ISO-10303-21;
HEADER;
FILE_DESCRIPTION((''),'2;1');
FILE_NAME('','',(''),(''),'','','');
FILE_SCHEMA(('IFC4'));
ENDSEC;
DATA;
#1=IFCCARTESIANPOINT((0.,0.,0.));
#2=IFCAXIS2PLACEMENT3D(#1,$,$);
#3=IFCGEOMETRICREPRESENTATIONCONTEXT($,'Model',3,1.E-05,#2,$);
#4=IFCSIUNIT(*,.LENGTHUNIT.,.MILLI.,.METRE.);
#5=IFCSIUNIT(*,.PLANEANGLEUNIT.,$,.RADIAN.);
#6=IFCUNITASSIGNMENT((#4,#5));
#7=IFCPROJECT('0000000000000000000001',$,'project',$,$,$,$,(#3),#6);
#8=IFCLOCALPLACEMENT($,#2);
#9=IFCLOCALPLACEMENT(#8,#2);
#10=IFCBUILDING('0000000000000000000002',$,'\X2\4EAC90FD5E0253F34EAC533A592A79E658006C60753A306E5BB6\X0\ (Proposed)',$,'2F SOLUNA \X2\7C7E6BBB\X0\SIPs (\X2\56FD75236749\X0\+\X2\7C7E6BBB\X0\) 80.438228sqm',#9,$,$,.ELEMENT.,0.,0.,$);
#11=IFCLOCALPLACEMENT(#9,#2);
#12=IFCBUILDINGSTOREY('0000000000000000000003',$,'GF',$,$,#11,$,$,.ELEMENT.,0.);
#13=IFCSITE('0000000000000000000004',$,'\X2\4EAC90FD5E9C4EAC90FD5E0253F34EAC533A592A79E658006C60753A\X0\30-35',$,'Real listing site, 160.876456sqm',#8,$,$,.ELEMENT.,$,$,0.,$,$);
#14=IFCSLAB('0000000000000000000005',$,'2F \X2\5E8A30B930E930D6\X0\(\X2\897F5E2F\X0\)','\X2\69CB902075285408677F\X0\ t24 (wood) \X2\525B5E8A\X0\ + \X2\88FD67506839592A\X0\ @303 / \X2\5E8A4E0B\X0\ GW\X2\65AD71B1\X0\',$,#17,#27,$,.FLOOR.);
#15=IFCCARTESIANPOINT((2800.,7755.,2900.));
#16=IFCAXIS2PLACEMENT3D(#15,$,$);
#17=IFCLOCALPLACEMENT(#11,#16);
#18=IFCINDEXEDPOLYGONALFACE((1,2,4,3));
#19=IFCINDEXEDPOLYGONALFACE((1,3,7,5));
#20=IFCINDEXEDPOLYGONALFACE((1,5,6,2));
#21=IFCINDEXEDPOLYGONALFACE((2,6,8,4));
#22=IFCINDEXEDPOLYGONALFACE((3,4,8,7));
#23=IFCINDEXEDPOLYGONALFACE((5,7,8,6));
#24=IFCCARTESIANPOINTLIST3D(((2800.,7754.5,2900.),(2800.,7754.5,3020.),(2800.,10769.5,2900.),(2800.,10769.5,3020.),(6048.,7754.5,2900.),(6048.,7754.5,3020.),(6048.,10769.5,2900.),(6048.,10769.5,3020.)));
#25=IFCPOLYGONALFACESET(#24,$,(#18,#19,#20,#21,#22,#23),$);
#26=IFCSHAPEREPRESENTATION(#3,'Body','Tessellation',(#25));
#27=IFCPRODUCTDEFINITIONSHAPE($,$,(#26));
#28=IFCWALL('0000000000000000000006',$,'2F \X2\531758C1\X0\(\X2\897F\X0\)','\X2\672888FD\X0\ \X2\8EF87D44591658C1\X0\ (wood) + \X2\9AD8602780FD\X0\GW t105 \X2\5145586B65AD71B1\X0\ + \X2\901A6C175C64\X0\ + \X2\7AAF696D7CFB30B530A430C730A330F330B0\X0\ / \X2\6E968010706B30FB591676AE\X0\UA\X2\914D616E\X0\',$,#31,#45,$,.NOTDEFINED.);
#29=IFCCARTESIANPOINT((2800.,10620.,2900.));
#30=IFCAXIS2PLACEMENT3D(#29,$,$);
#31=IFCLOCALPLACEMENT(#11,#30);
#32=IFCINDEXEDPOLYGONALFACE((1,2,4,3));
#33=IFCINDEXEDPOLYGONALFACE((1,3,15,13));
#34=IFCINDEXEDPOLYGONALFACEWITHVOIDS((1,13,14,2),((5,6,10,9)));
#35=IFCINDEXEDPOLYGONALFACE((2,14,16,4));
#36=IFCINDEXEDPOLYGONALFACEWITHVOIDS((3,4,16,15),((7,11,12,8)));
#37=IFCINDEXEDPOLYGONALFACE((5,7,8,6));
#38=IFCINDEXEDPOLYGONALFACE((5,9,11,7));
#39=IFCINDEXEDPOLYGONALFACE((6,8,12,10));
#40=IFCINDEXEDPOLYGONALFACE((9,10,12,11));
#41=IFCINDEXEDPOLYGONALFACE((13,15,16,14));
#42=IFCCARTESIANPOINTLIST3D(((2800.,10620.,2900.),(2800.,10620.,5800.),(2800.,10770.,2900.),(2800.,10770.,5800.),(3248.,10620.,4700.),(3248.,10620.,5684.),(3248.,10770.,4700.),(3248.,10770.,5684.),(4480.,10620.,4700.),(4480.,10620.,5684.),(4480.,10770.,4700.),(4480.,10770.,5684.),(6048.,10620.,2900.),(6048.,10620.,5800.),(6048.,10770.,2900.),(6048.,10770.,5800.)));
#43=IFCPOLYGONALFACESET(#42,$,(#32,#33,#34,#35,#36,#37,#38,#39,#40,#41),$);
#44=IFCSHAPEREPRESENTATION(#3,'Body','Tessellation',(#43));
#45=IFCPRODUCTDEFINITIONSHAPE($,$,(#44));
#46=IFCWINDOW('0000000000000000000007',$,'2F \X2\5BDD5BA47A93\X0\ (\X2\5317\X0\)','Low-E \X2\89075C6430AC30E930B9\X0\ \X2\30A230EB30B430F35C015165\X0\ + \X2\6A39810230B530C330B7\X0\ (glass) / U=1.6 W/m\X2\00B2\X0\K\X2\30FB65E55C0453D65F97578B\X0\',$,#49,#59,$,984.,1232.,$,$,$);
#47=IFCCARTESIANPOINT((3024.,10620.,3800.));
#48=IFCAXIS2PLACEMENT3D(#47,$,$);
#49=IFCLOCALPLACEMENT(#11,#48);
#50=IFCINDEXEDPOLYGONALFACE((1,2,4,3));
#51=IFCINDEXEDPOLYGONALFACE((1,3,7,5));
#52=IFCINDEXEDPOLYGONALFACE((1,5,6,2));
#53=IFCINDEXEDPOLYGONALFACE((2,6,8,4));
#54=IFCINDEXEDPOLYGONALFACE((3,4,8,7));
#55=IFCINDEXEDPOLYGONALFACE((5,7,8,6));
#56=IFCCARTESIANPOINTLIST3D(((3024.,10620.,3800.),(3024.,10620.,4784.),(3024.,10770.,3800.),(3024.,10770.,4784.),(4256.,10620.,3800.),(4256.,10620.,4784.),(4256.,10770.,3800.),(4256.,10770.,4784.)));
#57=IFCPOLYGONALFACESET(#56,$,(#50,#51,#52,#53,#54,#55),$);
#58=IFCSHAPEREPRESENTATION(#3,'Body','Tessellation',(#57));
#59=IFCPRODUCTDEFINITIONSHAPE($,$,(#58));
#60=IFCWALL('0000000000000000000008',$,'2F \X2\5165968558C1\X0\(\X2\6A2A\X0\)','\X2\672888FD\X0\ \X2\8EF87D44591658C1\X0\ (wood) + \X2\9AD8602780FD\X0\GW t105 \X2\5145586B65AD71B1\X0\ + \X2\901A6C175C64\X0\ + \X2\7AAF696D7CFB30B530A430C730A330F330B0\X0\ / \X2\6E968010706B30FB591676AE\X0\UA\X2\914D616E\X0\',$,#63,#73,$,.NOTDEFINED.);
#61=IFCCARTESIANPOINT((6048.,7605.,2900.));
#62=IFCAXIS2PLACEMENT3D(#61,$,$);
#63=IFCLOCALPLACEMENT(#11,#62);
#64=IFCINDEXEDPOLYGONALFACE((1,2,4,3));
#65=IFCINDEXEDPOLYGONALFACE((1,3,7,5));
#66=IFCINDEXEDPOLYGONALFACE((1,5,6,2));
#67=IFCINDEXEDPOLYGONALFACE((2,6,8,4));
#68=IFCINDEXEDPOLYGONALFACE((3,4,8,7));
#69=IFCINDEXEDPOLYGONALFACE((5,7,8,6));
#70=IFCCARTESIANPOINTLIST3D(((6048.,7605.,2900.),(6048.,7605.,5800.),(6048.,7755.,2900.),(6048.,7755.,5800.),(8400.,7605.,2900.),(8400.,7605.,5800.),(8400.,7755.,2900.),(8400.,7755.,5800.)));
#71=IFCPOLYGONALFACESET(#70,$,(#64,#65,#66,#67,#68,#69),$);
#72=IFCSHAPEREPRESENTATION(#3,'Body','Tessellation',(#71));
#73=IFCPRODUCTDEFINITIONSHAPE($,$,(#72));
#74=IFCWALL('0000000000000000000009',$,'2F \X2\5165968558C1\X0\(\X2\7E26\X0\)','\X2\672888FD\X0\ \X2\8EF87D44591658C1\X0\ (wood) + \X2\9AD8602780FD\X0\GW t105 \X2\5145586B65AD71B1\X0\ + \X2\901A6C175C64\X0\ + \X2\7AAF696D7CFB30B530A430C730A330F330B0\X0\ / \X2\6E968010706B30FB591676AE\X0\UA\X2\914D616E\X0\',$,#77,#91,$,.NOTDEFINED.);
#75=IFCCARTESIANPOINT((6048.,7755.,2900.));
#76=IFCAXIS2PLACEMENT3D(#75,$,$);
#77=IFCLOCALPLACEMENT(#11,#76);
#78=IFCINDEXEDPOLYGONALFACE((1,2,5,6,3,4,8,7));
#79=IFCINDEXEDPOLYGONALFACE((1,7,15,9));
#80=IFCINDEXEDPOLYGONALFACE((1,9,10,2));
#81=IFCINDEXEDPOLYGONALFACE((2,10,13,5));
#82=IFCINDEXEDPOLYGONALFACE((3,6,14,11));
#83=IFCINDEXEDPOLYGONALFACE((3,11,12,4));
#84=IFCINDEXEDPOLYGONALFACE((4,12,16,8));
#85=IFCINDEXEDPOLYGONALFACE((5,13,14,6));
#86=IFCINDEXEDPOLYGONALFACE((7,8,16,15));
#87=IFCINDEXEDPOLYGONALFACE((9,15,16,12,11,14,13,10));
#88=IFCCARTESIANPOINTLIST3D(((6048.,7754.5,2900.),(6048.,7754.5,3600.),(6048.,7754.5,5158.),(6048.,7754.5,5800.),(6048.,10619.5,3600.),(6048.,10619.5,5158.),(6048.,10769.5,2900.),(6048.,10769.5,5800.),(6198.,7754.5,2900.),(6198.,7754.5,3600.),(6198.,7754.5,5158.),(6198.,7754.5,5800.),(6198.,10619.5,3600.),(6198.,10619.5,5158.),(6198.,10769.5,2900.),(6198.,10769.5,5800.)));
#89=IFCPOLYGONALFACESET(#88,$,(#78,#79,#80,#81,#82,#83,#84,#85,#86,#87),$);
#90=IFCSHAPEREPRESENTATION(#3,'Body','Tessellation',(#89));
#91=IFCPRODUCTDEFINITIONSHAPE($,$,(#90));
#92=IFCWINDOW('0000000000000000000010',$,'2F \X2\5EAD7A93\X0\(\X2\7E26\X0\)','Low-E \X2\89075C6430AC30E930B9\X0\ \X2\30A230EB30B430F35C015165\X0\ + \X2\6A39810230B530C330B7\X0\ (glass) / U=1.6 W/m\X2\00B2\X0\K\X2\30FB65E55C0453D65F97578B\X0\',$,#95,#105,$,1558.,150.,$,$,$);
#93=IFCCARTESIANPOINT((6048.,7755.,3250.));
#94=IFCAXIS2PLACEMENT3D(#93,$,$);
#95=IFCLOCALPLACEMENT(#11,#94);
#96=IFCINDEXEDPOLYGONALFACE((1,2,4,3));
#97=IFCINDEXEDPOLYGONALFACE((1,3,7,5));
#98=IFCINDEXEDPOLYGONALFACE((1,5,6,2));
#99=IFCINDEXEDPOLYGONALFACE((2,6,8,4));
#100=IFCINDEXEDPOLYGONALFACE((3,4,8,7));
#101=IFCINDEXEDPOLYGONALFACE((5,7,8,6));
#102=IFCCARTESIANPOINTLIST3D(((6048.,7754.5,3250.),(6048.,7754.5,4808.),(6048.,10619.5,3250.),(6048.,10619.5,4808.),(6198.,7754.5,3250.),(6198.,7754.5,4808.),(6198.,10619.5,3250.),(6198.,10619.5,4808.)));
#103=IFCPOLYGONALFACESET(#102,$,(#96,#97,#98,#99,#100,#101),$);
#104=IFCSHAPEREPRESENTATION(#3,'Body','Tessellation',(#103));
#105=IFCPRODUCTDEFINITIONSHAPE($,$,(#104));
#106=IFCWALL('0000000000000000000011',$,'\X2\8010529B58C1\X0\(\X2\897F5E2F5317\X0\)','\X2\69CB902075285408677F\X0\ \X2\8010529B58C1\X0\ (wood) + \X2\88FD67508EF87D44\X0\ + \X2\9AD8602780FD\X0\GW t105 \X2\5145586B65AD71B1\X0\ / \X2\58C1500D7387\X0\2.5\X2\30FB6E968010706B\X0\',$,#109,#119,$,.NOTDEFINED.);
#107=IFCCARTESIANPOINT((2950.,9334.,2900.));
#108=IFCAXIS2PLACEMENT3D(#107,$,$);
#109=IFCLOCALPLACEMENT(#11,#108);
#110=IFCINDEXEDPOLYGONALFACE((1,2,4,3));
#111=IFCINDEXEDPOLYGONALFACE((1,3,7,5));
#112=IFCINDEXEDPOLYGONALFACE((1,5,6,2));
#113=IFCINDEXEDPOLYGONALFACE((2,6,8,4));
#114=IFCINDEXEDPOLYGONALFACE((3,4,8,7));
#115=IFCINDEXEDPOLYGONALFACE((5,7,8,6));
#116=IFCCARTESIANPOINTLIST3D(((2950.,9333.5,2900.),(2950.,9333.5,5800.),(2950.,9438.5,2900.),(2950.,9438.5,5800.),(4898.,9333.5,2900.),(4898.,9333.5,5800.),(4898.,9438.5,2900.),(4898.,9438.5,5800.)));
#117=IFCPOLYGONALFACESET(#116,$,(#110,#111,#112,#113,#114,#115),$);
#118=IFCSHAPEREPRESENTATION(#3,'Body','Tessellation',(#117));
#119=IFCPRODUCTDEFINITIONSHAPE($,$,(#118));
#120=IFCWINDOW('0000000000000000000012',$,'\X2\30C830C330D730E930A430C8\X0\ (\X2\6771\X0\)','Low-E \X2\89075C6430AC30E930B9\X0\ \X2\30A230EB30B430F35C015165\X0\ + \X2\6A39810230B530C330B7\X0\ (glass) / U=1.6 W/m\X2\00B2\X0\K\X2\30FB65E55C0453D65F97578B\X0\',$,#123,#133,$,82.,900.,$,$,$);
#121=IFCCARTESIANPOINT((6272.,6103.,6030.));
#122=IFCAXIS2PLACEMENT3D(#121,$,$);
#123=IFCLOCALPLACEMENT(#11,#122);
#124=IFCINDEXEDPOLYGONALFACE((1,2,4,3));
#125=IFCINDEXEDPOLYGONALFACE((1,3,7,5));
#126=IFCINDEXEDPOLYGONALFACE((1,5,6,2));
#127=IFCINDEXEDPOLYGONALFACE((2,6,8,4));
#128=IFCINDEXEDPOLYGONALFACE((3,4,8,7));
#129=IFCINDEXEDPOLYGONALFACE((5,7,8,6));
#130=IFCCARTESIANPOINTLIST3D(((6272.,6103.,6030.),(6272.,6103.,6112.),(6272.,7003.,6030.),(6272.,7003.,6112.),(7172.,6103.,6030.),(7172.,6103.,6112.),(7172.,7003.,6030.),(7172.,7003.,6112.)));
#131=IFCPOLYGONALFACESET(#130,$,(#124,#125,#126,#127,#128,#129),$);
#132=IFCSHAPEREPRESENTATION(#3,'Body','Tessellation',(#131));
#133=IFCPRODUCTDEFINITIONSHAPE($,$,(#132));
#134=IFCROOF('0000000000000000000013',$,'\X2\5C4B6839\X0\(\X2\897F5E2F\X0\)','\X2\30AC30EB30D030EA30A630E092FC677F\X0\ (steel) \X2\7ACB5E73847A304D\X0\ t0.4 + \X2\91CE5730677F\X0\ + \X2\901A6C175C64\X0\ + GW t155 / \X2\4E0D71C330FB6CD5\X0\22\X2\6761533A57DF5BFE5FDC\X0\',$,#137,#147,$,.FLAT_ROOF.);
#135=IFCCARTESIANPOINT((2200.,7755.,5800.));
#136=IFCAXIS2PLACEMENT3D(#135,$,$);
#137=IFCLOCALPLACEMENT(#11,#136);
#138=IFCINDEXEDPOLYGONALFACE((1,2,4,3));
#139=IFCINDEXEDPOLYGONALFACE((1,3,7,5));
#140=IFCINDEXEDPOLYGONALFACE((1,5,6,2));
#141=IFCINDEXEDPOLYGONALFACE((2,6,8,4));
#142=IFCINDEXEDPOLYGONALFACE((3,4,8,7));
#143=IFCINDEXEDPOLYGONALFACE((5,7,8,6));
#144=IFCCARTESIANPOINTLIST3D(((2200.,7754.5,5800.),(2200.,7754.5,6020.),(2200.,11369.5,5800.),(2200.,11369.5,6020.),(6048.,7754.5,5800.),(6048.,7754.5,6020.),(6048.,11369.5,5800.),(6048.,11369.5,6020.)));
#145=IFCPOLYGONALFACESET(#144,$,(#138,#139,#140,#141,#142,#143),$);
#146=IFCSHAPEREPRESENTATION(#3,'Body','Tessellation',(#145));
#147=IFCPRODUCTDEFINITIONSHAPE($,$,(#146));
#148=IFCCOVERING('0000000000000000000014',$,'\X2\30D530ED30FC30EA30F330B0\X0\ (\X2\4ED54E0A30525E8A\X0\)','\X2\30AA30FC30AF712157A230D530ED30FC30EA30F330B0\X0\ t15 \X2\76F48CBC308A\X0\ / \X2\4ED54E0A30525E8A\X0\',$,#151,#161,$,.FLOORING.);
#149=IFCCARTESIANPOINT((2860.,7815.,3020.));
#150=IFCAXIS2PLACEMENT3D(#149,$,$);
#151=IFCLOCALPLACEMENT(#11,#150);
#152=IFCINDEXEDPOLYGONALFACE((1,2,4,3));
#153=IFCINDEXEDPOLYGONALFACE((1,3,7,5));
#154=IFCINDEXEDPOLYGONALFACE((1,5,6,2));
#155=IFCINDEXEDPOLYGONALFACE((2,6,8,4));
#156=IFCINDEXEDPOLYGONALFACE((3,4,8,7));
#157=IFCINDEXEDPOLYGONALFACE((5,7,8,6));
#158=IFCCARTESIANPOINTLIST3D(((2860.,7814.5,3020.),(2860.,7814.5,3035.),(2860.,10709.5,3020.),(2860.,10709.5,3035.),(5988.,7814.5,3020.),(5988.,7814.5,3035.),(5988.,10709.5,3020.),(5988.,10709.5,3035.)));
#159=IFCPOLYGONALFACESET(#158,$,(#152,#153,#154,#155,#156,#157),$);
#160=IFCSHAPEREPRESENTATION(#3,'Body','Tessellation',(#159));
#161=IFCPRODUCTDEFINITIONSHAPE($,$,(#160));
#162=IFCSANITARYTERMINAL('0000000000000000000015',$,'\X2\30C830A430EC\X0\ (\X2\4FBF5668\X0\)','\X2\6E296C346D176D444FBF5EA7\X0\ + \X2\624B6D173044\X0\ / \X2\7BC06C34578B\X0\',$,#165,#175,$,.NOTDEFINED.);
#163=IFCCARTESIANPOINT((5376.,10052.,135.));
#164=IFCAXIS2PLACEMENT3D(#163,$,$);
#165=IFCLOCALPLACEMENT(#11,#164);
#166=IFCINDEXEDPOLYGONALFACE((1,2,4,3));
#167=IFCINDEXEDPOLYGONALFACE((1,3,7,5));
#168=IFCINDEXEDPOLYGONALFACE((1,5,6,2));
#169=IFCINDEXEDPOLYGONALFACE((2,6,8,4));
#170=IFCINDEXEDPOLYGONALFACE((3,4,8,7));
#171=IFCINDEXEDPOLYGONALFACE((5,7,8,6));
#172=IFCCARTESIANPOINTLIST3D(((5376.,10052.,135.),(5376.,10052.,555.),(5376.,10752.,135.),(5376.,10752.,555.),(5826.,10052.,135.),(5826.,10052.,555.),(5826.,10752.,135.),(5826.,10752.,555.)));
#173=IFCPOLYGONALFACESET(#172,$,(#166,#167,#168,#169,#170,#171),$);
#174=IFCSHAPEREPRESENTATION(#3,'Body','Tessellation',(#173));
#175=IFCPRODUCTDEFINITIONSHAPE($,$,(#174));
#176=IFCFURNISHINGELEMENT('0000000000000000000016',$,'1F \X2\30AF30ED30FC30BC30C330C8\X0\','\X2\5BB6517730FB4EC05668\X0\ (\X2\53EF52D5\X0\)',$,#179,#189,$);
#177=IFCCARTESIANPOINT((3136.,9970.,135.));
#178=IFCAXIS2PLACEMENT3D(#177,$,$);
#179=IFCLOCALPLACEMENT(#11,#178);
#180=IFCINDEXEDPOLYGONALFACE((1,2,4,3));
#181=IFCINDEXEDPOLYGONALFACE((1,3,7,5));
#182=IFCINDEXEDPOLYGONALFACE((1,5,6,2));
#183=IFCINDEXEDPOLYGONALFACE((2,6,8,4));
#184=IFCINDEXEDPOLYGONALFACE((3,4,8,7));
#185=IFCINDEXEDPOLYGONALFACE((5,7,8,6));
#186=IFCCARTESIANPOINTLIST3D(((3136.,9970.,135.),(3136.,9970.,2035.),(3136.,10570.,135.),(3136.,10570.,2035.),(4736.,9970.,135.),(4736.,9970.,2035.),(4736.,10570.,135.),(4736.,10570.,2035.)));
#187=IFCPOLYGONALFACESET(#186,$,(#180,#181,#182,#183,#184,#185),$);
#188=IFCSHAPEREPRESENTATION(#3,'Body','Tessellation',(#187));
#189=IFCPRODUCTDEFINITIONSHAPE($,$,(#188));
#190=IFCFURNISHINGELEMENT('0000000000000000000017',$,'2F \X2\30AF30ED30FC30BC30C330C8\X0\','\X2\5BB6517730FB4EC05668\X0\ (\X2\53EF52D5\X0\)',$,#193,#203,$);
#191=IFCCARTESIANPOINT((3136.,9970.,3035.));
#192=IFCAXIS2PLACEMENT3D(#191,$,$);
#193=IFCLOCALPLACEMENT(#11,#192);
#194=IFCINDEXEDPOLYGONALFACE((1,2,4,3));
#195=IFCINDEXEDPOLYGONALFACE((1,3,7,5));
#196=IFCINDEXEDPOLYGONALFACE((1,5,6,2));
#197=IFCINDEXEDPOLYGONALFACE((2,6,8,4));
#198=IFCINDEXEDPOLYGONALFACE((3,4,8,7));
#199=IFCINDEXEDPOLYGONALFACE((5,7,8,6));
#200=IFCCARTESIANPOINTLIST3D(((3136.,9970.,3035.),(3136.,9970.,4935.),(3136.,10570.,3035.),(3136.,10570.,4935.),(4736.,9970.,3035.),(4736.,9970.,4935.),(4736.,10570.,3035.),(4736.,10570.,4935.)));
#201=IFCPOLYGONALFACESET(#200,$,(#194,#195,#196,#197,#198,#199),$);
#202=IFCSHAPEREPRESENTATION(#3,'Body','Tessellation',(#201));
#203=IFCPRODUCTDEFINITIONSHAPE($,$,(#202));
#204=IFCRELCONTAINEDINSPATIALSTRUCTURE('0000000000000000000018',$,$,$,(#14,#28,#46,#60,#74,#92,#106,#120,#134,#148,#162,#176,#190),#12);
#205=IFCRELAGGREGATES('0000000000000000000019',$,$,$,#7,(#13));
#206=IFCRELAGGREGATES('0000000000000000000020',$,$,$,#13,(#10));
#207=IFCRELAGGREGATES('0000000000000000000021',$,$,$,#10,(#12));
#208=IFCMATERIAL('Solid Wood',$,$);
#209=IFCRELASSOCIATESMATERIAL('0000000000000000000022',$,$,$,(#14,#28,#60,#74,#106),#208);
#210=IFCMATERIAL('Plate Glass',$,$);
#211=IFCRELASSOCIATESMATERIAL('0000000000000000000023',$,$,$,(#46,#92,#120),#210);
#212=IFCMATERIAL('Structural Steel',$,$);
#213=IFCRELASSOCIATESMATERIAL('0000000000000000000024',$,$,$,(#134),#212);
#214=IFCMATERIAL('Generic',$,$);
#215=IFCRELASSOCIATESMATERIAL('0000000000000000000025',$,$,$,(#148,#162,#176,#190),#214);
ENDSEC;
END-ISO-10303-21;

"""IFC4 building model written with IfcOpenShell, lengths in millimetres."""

from ifc_helpers import new_model, si_unit, frame, frame_2d, origin, place, context, project, spatial, rectangle, extrude, material, element, fill, save


model = new_model("IFC4")

# Units and contexts
model_context = context("Model", 3, precision=1e-05, world=origin())
ifc_project = project(units=[si_unit("LENGTHUNIT", "METRE", prefix="MILLI"), si_unit("PLANEANGLEUNIT", "RADIAN")], contexts=[model_context])

# Site, building, storey
site_placement = place(None, origin())
site = spatial("IfcSite", under=ifc_project, at=site_placement, Name="京都府京都市右京区太秦堀池町30-35", ObjectType="Real listing site, 160.876456sqm", CompositionType="ELEMENT", RefElevation=0.0)
building_placement = place(site_placement, origin())
building = spatial("IfcBuilding", under=site, at=building_placement, Name="京都市右京区太秦堀池町の家 (Proposed)", ObjectType="2F SOLUNA 籾殻SIPs (国産杉+籾殻) 80.438228sqm", CompositionType="ELEMENT", ElevationOfRefHeight=0.0, ElevationOfTerrain=0.0)
storey_placement = place(building_placement, origin())
storey = spatial("IfcBuildingStorey", under=building, at=storey_placement, Name="GF", CompositionType="ELEMENT", Elevation=0.0)

# Slab
ifc_material_1 = material(Name="Solid Wood")
slab_placement = place(storey_placement, frame((2800.0, 7755.0, 2900.0)))
element("IfcSlab", 1, at=slab_placement, inside=storey, material=ifc_material_1, Name="2F 床スラブ(西帯)", Description="構造用合板 t24 (wood) 剛床 + 製材根太 @303 / 床下 GW断熱", PredefinedType="FLOOR", context=model_context, shape_type="SweptSolid", body=[
    extrude(rectangle(XDim=3248.0, YDim=3015.0, at=frame_2d((1624.0, 1507.0))), frame((2800.0, 7755.0, 2900.0)), (0.0, 0.0, 1.0), 120.0),
])

# Wall, opening, window
wall_1_placement = place(storey_placement, frame((2800.0, 10620.0, 2900.0)))
wall_1 = element("IfcWall", 2, at=wall_1_placement, inside=storey, material=ifc_material_1, Name="2F 北壁(西)", Description="木製 軸組外壁 (wood) + 高性能GW t105 充填断熱 + 通気層 + 窯業系サイディング / 準耐火・外皮UA配慮", PredefinedType="NOTDEFINED", context=model_context, shape_type="SweptSolid", body=[
    extrude(rectangle(XDim=3248.0, YDim=150.0, at=frame_2d((1624.0, 75.0))), frame((2800.0, 10620.0, 2900.0)), (0.0, 0.0, 1.0), 2900.0),
])
opening_1_placement = place(storey_placement, frame((3024.0, 10620.0, 3800.0)))
opening_1 = element("IfcOpeningElement", 3, at=opening_1_placement, cuts=wall_1, PredefinedType="NOTDEFINED", context=model_context, shape_type="SweptSolid", body=[
    extrude(rectangle(XDim=1232.0, YDim=150.0, at=frame_2d((616.0, 75.0))), frame((3024.0, 10620.0, 3800.0)), (0.0, 0.0, 1.0), 984.0),
])
ifc_material_2 = material(Name="Plate Glass")
window_1_placement = place(storey_placement, frame((3024.0, 10620.0, 3800.0)))
window_1 = element("IfcWindow", 4, at=window_1_placement, inside=storey, material=ifc_material_2, Name="2F 寝室窓 (北)", Description="Low-E 複層ガラス アルゴン封入 + 樹脂サッシ (glass) / U=1.6 W/m²K・日射取得型", OverallHeight=984.0, OverallWidth=1232.0, context=model_context, shape_type="SweptSolid", body=[
    extrude(rectangle(XDim=1232.0, YDim=150.0, at=frame_2d((616.0, 75.0))), frame((3024.0, 10620.0, 3800.0)), (0.0, 0.0, 1.0), 984.0),
])
fill(opening_1, window_1)

# Wall
wall_2_placement = place(storey_placement, frame((6048.0, 7605.0, 2900.0)))
element("IfcWall", 5, at=wall_2_placement, inside=storey, material=ifc_material_1, Name="2F 入隅壁(横)", Description="木製 軸組外壁 (wood) + 高性能GW t105 充填断熱 + 通気層 + 窯業系サイディング / 準耐火・外皮UA配慮", PredefinedType="NOTDEFINED", context=model_context, shape_type="SweptSolid", body=[
    extrude(rectangle(XDim=2352.0, YDim=150.0, at=frame_2d((1176.0, 75.0))), frame((6048.0, 7605.0, 2900.0)), (0.0, 0.0, 1.0), 2900.0),
])

# Wall, opening, window
wall_3_placement = place(storey_placement, frame((6048.0, 7755.0, 2900.0)))
wall_3 = element("IfcWall", 6, at=wall_3_placement, inside=storey, material=ifc_material_1, Name="2F 入隅壁(縦)", Description="木製 軸組外壁 (wood) + 高性能GW t105 充填断熱 + 通気層 + 窯業系サイディング / 準耐火・外皮UA配慮", PredefinedType="NOTDEFINED", context=model_context, shape_type="SweptSolid", body=[
    extrude(rectangle(XDim=150.0, YDim=3015.0, at=frame_2d((75.0, 1507.0))), frame((6048.0, 7755.0, 2900.0)), (0.0, 0.0, 1.0), 2900.0),
])
opening_2_placement = place(storey_placement, frame((6048.0, 7755.0, 3250.0)))
opening_2 = element("IfcOpeningElement", 7, at=opening_2_placement, cuts=wall_3, PredefinedType="NOTDEFINED", context=model_context, shape_type="SweptSolid", body=[
    extrude(rectangle(XDim=150.0, YDim=2865.0, at=frame_2d((75.0, 1432.0))), frame((6048.0, 7755.0, 3250.0)), (0.0, 0.0, 1.0), 1558.0),
])
window_2_placement = place(storey_placement, frame((6048.0, 7755.0, 3250.0)))
window_2 = element("IfcWindow", 8, at=window_2_placement, inside=storey, material=ifc_material_2, Name="2F 庭窓(縦)", Description="Low-E 複層ガラス アルゴン封入 + 樹脂サッシ (glass) / U=1.6 W/m²K・日射取得型", OverallHeight=1558.0, OverallWidth=150.0, context=model_context, shape_type="SweptSolid", body=[
    extrude(rectangle(XDim=150.0, YDim=2865.0, at=frame_2d((75.0, 1432.0))), frame((6048.0, 7755.0, 3250.0)), (0.0, 0.0, 1.0), 1558.0),
])
fill(opening_2, window_2)

# Wall
wall_4_placement = place(storey_placement, frame((2950.0, 9334.0, 2900.0)))
element("IfcWall", 9, at=wall_4_placement, inside=storey, material=ifc_material_1, Name="耐力壁(西帯北)", Description="構造用合板 耐力壁 (wood) + 製材軸組 + 高性能GW t105 充填断熱 / 壁倍率2.5・準耐火", PredefinedType="NOTDEFINED", context=model_context, shape_type="SweptSolid", body=[
    extrude(rectangle(XDim=1948.0, YDim=105.0, at=frame_2d((974.0, 52.0))), frame((2950.0, 9334.0, 2900.0)), (0.0, 0.0, 1.0), 2900.0),
])

# Window
window_3_placement = place(storey_placement, frame((6272.0, 6103.0, 6030.0)))
element("IfcWindow", 10, at=window_3_placement, inside=storey, material=ifc_material_2, Name="トップライト (東)", Description="Low-E 複層ガラス アルゴン封入 + 樹脂サッシ (glass) / U=1.6 W/m²K・日射取得型", OverallHeight=82.0, OverallWidth=900.0, context=model_context, shape_type="SweptSolid", body=[
    extrude(rectangle(XDim=900.0, YDim=900.0, at=frame_2d((450.0, 450.0))), frame((6272.0, 6103.0, 6030.0)), (0.0, 0.0, 1.0), 82.0),
])

# Roof
ifc_material_3 = material(Name="Structural Steel")
for number, where, name in (
    (11, (2200.0, 7755.0, 5800.0), "屋根(西帯)"),
):
    element("IfcRoof", number, at=place(storey_placement, frame(where)), inside=storey, material=ifc_material_3, Name=name, Description="ガルバリウム鋼板 (steel) 立平葺き t0.4 + 野地板 + 通気層 + GW t155 / 不燃・法22条区域対応", PredefinedType="FLAT_ROOF", context=model_context, shape_type="SweptSolid", body=[
        extrude(rectangle(XDim=3848.0, YDim=3615.0, at=frame_2d((1924.0, 1807.0))), frame((2200.0, 7755.0, 5800.0)), (0.0, 0.0, 1.0), 220.0),
    ])

# Covering
ifc_material_4 = material(Name="Generic")
covering_placement = place(storey_placement, frame((2860.0, 7815.0, 3020.0)))
element("IfcCovering", 12, at=covering_placement, inside=storey, material=ifc_material_4, Name="フローリング (仕上げ床)", Description="オーク無垢フローリング t15 直貼り / 仕上げ床", PredefinedType="FLOORING", context=model_context, shape_type="SweptSolid", body=[
    extrude(rectangle(XDim=3128.0, YDim=2895.0, at=frame_2d((1564.0, 1447.0))), frame((2860.0, 7815.0, 3020.0)), (0.0, 0.0, 1.0), 15.0),
])

# Sanitary terminal
sanitary_terminal_placement = place(storey_placement, frame((5376.0, 10052.0, 135.0)))
element("IfcSanitaryTerminal", 13, at=sanitary_terminal_placement, inside=storey, material=ifc_material_4, Name="トイレ (便器)", Description="温水洗浄便座 + 手洗い / 節水型", PredefinedType="NOTDEFINED", context=model_context, shape_type="SweptSolid", body=[
    extrude(rectangle(XDim=450.0, YDim=700.0, at=frame_2d((225.0, 350.0))), frame((5376.0, 10052.0, 135.0)), (0.0, 0.0, 1.0), 420.0),
])

# Furnishing elements
furnishing_1_placement = place(storey_placement, frame((3136.0, 9970.0, 135.0)))
element("IfcFurnishingElement", 14, at=furnishing_1_placement, inside=storey, material=ifc_material_4, Name="1F クローゼット", Description="家具・什器 (可動)", context=model_context, shape_type="SweptSolid", body=[
    extrude(rectangle(XDim=1600.0, YDim=600.0, at=frame_2d((800.0, 300.0))), frame((3136.0, 9970.0, 135.0)), (0.0, 0.0, 1.0), 1900.0),
])
furnishing_2_placement = place(storey_placement, frame((3136.0, 9970.0, 3035.0)))
element("IfcFurnishingElement", 15, at=furnishing_2_placement, inside=storey, material=ifc_material_4, Name="2F クローゼット", Description="家具・什器 (可動)", context=model_context, shape_type="SweptSolid", body=[
    extrude(rectangle(XDim=1600.0, YDim=600.0, at=frame_2d((800.0, 300.0))), frame((3136.0, 9970.0, 3035.0)), (0.0, 0.0, 1.0), 1900.0),
])

save(model, "model.ifc")
